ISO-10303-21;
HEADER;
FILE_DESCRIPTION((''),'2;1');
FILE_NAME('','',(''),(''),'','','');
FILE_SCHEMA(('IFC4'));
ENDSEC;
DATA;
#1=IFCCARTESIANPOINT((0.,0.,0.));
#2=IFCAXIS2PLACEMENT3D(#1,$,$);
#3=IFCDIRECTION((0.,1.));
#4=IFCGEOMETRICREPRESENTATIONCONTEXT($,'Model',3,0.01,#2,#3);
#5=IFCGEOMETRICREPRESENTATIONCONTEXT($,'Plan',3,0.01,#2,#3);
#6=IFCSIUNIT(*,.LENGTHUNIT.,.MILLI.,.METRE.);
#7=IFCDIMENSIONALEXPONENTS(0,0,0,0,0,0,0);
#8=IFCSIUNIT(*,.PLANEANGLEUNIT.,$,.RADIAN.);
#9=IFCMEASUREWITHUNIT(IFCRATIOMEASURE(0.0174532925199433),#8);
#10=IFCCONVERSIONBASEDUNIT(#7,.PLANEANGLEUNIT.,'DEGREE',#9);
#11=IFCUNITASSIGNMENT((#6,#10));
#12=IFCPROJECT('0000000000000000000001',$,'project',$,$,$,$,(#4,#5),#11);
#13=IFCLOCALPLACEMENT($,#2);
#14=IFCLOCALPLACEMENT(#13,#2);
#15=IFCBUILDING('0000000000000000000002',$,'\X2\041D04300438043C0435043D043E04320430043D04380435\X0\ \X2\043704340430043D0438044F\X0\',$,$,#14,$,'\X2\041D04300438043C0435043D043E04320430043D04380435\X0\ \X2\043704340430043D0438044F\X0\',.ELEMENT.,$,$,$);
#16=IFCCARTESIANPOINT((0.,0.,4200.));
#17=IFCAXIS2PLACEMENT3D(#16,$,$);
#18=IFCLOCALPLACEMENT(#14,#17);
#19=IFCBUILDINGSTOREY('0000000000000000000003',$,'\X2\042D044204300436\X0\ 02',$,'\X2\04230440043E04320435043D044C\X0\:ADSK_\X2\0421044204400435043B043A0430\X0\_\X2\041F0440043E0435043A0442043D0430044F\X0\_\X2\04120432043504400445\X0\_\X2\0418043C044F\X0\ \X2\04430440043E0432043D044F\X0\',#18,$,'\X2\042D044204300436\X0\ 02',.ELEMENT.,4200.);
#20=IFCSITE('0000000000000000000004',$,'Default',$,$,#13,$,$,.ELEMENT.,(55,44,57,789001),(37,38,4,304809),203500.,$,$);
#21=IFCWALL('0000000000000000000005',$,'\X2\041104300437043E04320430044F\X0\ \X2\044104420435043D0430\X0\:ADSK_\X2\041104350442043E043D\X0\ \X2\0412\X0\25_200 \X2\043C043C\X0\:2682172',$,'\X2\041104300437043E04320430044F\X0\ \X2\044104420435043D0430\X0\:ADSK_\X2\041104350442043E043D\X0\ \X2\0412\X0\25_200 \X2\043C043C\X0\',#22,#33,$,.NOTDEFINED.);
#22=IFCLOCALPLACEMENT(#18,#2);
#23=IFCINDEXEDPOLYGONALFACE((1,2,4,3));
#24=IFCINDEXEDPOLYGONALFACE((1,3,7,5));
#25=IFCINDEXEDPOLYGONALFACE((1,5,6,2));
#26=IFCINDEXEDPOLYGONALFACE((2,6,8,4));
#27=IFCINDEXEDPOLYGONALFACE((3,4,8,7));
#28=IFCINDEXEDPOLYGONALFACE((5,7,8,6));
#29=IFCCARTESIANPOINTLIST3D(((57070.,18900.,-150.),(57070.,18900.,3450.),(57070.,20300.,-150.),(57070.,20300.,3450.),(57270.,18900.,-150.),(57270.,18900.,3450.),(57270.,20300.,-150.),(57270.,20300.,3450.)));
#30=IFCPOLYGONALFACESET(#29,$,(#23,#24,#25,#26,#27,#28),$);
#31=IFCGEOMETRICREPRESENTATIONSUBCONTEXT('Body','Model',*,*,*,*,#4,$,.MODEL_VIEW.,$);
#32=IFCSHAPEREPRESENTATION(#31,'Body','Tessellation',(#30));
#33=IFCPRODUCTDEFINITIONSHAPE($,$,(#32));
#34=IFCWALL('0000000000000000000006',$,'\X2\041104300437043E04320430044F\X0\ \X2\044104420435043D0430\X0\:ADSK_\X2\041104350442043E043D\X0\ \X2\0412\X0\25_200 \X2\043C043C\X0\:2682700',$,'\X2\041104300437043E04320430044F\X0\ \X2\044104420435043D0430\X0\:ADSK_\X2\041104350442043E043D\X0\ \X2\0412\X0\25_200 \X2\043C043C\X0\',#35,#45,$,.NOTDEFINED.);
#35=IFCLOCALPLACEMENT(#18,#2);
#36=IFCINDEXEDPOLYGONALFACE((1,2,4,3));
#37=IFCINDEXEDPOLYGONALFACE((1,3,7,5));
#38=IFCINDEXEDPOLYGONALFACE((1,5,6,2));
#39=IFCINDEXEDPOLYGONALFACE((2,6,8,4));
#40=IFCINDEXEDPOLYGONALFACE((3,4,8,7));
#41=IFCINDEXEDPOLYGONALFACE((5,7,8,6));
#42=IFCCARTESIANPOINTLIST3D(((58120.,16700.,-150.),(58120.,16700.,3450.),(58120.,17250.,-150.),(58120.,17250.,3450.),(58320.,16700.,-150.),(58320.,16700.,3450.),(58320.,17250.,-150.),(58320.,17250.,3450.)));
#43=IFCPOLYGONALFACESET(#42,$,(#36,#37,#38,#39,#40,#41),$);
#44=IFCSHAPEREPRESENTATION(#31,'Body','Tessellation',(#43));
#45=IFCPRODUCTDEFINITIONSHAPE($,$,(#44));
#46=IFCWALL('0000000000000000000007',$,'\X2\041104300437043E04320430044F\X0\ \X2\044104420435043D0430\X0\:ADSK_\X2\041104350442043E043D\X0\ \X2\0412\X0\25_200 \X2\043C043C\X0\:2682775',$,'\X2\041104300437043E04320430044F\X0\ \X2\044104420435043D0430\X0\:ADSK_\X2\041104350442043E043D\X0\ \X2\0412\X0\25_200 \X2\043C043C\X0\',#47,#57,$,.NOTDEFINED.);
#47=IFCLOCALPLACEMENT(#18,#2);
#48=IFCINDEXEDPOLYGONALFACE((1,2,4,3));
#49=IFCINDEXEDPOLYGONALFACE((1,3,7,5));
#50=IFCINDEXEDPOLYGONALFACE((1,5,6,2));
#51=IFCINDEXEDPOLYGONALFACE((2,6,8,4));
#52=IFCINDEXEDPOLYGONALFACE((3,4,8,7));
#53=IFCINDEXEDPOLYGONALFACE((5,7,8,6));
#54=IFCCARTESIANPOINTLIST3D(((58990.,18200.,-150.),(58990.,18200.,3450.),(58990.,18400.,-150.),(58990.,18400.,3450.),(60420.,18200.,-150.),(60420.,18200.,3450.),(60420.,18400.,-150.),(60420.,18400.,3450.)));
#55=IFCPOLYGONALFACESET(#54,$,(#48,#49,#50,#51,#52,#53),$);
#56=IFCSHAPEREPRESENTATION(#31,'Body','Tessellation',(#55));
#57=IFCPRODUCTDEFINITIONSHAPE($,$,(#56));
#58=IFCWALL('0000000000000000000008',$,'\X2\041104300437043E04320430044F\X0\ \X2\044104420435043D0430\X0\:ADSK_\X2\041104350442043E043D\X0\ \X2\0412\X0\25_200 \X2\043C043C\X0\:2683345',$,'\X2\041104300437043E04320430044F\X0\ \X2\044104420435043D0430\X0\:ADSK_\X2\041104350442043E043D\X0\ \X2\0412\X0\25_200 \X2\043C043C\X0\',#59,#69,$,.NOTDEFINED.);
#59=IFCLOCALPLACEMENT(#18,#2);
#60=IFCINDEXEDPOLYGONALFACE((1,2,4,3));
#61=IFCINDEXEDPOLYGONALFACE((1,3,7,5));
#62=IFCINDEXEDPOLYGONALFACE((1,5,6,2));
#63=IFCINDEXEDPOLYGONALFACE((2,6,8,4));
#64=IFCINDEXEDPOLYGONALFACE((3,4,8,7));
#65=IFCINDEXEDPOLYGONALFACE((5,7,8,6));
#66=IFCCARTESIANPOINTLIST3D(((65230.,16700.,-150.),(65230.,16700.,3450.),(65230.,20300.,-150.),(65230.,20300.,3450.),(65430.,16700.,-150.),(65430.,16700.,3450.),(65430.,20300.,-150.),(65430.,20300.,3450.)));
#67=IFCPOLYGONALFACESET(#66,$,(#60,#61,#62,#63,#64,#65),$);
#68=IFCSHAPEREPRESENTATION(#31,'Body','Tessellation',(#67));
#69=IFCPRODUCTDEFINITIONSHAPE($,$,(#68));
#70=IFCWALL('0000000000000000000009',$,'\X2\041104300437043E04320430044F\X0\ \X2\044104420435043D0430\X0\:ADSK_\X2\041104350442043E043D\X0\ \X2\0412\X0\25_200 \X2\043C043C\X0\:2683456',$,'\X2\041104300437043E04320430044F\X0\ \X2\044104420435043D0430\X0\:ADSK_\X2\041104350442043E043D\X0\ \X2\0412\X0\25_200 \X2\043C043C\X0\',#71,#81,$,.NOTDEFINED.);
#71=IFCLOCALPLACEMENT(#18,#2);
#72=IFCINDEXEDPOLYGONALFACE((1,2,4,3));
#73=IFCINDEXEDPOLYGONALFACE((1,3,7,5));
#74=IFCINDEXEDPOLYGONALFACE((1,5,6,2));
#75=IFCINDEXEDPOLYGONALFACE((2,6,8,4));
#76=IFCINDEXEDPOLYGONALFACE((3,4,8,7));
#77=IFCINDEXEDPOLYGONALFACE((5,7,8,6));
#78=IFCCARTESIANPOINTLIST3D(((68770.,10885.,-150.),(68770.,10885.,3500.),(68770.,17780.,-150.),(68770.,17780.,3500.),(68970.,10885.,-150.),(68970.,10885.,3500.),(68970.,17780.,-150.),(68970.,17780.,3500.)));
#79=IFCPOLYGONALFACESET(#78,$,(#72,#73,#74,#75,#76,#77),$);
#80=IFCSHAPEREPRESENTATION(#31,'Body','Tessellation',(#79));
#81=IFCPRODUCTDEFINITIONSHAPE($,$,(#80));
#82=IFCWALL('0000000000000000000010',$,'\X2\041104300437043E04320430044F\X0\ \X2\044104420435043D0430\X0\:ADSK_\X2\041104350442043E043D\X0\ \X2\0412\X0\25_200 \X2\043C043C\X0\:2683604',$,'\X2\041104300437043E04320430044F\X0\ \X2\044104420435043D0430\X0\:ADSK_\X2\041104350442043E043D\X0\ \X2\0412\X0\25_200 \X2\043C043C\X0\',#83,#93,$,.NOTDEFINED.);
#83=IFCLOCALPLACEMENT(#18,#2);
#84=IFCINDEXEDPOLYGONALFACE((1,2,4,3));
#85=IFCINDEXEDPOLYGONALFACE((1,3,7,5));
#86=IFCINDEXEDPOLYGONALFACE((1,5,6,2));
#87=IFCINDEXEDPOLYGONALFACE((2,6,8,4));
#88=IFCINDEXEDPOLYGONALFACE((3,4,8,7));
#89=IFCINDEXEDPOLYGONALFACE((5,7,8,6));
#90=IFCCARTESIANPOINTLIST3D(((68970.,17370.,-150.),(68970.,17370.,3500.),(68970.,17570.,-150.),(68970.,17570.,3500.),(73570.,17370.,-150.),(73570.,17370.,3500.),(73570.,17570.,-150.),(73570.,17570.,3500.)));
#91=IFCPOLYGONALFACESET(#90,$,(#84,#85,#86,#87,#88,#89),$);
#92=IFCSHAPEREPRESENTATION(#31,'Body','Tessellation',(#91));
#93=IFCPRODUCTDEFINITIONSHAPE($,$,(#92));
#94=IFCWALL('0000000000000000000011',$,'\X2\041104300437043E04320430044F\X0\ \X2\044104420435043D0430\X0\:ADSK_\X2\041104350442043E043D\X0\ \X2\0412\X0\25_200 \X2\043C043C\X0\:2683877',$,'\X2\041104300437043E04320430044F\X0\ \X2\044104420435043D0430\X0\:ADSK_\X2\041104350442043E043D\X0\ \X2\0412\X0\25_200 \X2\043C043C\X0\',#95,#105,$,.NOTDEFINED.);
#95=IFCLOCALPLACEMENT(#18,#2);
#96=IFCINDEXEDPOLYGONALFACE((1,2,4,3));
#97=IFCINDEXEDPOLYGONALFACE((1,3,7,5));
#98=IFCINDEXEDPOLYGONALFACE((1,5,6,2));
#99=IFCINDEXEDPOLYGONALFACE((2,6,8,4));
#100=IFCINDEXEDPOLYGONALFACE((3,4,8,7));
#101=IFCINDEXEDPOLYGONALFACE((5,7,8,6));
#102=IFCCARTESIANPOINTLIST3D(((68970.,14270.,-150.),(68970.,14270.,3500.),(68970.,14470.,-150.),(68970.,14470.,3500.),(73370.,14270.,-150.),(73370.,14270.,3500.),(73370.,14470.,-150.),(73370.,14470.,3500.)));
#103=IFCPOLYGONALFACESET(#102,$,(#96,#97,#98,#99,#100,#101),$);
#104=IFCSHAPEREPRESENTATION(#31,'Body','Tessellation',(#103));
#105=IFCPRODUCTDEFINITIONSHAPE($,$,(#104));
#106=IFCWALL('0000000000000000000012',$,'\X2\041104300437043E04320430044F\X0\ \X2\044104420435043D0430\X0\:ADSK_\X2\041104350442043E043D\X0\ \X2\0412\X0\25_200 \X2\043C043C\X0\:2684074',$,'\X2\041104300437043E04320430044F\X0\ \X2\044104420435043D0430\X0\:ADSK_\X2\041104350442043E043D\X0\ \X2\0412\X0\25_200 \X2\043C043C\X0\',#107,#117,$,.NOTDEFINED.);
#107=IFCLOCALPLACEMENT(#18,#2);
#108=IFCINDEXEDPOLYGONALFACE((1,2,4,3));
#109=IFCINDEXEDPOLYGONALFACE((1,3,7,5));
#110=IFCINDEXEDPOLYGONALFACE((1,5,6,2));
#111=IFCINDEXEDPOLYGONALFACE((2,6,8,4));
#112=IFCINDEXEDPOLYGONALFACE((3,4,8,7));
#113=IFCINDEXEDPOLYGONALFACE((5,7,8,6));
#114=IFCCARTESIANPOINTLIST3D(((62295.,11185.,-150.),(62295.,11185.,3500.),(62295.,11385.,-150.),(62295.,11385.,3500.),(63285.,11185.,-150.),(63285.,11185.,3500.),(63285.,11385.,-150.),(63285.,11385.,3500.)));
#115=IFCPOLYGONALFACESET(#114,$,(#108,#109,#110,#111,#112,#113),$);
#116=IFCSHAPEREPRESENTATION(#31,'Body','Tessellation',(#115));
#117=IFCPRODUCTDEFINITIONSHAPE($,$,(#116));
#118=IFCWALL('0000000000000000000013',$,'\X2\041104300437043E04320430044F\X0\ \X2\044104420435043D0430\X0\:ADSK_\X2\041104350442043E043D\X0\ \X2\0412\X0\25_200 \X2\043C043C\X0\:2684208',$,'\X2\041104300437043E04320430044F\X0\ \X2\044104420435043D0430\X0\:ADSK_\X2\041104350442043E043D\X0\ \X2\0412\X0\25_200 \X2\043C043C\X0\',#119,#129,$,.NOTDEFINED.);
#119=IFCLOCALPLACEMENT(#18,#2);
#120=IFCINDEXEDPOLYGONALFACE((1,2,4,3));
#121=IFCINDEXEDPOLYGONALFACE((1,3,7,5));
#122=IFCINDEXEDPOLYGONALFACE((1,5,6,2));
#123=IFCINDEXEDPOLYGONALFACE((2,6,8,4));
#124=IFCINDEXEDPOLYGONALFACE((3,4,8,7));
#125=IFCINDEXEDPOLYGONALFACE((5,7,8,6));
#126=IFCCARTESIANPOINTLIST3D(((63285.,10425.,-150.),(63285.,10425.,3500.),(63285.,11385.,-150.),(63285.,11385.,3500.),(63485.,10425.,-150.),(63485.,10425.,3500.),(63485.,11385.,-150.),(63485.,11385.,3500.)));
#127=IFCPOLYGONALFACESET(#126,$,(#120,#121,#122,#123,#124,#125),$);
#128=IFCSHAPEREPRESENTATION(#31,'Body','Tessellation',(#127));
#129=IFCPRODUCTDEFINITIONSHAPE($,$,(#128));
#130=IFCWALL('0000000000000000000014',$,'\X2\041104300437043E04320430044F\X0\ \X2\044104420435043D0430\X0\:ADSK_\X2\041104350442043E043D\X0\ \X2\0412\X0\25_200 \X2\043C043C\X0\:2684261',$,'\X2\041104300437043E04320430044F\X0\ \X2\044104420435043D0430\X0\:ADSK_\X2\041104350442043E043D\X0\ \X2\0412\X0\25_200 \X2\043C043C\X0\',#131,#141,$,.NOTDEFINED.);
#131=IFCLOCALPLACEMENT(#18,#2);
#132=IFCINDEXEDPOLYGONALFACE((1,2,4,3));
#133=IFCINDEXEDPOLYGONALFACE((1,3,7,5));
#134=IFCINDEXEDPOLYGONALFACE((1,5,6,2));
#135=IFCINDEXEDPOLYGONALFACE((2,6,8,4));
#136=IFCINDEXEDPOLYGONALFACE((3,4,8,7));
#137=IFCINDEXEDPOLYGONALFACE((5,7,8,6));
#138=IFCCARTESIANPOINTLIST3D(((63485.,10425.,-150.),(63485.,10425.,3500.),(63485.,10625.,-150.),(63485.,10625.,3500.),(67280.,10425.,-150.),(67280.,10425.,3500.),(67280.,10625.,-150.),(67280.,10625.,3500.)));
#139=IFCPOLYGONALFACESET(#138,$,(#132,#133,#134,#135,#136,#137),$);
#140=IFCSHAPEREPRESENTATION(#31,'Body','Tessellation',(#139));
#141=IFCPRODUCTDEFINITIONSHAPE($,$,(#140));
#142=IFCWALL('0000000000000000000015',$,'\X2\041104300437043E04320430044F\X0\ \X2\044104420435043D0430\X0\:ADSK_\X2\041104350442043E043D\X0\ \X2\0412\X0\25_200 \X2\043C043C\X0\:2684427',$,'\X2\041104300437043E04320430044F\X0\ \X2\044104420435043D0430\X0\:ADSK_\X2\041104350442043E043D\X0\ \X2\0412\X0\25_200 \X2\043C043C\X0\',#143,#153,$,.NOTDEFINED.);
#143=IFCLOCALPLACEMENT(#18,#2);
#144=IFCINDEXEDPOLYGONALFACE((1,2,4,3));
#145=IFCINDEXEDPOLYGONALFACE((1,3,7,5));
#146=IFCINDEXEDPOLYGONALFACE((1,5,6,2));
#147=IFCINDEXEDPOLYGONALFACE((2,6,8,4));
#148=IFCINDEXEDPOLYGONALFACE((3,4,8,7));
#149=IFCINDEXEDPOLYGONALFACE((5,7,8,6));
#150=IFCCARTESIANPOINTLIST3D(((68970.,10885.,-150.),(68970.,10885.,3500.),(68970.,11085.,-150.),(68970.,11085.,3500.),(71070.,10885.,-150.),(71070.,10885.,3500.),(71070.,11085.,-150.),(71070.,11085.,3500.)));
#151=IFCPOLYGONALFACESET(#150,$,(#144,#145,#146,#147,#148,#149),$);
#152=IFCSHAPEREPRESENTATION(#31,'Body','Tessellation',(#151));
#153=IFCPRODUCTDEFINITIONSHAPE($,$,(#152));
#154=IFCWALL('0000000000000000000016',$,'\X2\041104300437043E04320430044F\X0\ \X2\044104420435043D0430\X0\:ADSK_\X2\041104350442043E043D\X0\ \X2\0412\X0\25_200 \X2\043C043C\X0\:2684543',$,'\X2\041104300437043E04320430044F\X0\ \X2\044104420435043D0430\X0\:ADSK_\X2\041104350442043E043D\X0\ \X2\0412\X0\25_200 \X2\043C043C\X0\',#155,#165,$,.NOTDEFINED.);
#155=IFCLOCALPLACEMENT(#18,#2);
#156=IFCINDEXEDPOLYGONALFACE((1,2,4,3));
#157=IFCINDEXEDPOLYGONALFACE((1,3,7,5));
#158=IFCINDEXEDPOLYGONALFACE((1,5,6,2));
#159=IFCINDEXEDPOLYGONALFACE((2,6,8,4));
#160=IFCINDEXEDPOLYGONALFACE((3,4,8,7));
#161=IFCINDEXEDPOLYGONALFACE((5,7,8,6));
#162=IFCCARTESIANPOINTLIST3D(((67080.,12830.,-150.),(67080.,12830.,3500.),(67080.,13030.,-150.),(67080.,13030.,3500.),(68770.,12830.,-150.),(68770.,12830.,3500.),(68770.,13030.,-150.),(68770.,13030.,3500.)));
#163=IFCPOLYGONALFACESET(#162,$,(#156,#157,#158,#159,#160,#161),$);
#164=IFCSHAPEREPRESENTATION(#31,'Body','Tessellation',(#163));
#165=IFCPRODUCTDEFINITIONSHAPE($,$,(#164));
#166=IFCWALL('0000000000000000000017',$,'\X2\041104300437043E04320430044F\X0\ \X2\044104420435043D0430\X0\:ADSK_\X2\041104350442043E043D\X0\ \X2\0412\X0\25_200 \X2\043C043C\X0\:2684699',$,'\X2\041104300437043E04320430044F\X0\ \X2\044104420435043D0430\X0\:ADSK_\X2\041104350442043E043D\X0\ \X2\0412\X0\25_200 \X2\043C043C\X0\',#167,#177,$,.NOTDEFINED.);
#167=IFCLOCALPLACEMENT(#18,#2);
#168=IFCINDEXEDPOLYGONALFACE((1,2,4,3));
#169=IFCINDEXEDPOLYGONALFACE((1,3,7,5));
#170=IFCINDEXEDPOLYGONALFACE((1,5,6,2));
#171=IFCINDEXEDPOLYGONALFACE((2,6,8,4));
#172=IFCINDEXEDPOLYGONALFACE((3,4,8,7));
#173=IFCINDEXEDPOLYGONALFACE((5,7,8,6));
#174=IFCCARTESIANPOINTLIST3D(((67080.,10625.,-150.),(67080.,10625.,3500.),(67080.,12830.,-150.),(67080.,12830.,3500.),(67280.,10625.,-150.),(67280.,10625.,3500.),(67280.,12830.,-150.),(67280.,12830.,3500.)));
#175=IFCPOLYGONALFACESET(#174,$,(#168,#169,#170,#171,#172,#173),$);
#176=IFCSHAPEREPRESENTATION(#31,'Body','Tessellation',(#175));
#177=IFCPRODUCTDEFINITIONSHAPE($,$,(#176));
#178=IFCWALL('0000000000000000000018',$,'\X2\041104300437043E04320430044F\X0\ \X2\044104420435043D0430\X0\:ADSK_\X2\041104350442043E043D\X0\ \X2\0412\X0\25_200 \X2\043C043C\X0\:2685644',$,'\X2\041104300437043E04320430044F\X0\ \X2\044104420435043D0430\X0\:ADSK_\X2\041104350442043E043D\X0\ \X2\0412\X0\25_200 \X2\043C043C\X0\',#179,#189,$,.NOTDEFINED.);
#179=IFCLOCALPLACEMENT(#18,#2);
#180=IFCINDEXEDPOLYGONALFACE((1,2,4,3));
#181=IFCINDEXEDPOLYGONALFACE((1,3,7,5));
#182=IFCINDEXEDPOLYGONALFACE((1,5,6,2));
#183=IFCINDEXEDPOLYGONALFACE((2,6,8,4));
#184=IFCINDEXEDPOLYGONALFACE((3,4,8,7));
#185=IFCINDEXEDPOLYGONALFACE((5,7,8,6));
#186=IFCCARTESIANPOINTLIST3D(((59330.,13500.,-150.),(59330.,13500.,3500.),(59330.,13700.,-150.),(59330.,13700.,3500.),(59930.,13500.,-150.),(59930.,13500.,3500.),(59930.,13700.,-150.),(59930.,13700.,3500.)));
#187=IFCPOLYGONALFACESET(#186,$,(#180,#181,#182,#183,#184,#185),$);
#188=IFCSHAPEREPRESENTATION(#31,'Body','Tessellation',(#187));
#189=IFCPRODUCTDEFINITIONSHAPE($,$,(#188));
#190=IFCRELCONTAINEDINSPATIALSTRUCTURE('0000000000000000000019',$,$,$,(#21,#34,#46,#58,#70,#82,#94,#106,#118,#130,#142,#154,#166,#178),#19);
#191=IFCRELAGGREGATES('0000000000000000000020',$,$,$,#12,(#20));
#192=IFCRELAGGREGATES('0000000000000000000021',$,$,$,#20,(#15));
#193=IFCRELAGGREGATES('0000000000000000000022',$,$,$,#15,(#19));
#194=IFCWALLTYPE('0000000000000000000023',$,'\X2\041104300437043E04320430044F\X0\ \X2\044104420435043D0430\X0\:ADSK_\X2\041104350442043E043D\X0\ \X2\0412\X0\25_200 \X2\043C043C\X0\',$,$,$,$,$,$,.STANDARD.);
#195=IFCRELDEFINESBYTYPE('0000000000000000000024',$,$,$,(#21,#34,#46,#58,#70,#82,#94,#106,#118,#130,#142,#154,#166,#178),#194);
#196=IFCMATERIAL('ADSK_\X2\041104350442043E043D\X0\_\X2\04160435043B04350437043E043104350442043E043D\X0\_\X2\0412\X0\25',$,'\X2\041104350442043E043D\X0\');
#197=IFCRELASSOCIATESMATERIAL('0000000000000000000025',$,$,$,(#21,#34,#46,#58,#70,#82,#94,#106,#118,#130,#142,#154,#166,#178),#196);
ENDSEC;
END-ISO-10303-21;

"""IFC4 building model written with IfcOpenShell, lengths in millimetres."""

from ifc_helpers import new_model, entity, si_unit, converted_unit, direction, frame, origin, place, context, subcontext, project, spatial, indexed_curve, outline, extrude, material, type_object, element, save


model = new_model("IFC4")

# Units and contexts
model_context = context("Model", 3, precision=0.01, world=origin(), true_north=direction((0.0, 1.0)))
plan_context = context("Plan", 3, precision=0.01, world=origin(), true_north=direction((0.0, 1.0)))
body_context = subcontext(model_context, "Body", "Model", "MODEL_VIEW")
ifc_project = project(units=[si_unit("LENGTHUNIT", "METRE", prefix="MILLI"), converted_unit("PLANEANGLEUNIT", "DEGREE", entity("IfcRatioMeasure", 0.0174532925199433), si_unit("PLANEANGLEUNIT", "RADIAN"), dimensions=[0, 0, 0, 0, 0, 0, 0])], contexts=[model_context, plan_context])

# Site, building, storey
site_placement = place(None, origin())
site = spatial("IfcSite", under=ifc_project, at=site_placement, Name="Default", CompositionType="ELEMENT", RefLatitude=(55, 44, 57, 789001), RefLongitude=(37, 38, 4, 304809), RefElevation=203500.0)
building_placement = place(site_placement, origin())
building = spatial("IfcBuilding", under=site, at=building_placement, Name="Наименование здания", LongName="Наименование здания", CompositionType="ELEMENT")
storey_placement = place(building_placement, frame((0.0, 0.0, 4200.0)))
storey = spatial("IfcBuildingStorey", under=building, at=storey_placement, Name="Этаж 02", ObjectType="Уровень:ADSK_Стрелка_Проектная_Вверх_Имя уровня", LongName="Этаж 02", CompositionType="ELEMENT", Elevation=4200.0)

# Walls
ifc_material = material(Name="ADSK_Бетон_Железобетон_В25", Category="Бетон")
wall_type_1 = type_object("IfcWallType", Name="Базовая стена:ADSK_Бетон В25_200 мм", PredefinedType="STANDARD")
wall_1_placement = place(storey_placement, frame((57170.0, 20300.0, -150.0), z_axis=(0.0, 0.0, 1.0), x_axis=(0.0, -1.0, 0.0)))
element("IfcWall", 1, at=wall_1_placement, inside=storey, type_object=wall_type_1, material=ifc_material, Name="Базовая стена:ADSK_Бетон В25_200 мм:2682172", ObjectType="Базовая стена:ADSK_Бетон В25_200 мм", PredefinedType="NOTDEFINED", context=body_context, shape_type="SweptSolid", body=[
    extrude(outline(indexed_curve([(1400.0, 100.0), (0.0, 100.0), (0.0, -100.0), (1400.0, -100.0), (1400.0, 100.0)], self_intersect=False)), origin(), (0.0, 0.0, 1.0), 3600.0),
])
wall_2_placement = place(storey_placement, frame((58220.0, 16700.0, -150.0), z_axis=(0.0, 0.0, 1.0), x_axis=(0.0, 1.0, 0.0)))
element("IfcWall", 2, at=wall_2_placement, inside=storey, type_object=wall_type_1, material=ifc_material, Name="Базовая стена:ADSK_Бетон В25_200 мм:2682700", ObjectType="Базовая стена:ADSK_Бетон В25_200 мм", PredefinedType="NOTDEFINED", context=body_context, shape_type="SweptSolid", body=[
    extrude(outline(indexed_curve([(550.0, 100.0), (0.0, 100.0), (0.0, -100.0), (550.0, -100.0), (550.0, 100.0)], self_intersect=False)), origin(), (0.0, 0.0, 1.0), 3600.0),
])
wall_3_placement = place(storey_placement, frame((60420.0, 18300.0, -150.0), z_axis=(0.0, 0.0, 1.0), x_axis=(-1.0, 0.0, 0.0)))
element("IfcWall", 3, at=wall_3_placement, inside=storey, type_object=wall_type_1, material=ifc_material, Name="Базовая стена:ADSK_Бетон В25_200 мм:2682775", ObjectType="Базовая стена:ADSK_Бетон В25_200 мм", PredefinedType="NOTDEFINED", context=body_context, shape_type="SweptSolid", body=[
    extrude(outline(indexed_curve([(1430.0, 100.0), (0.0, 100.0), (0.0, -100.0), (1430.0, -100.0), (1430.0, 100.0)], self_intersect=False)), origin(), (0.0, 0.0, 1.0), 3600.0),
])
wall_4_placement = place(storey_placement, frame((65330.0, 16700.0, -150.0), z_axis=(0.0, 0.0, 1.0), x_axis=(0.0, 1.0, 0.0)))
element("IfcWall", 4, at=wall_4_placement, inside=storey, type_object=wall_type_1, material=ifc_material, Name="Базовая стена:ADSK_Бетон В25_200 мм:2683345", ObjectType="Базовая стена:ADSK_Бетон В25_200 мм", PredefinedType="NOTDEFINED", context=body_context, shape_type="SweptSolid", body=[
    extrude(outline(indexed_curve([(3600.0, 100.0), (0.0, 100.0), (0.0, -100.0), (3600.0, -100.0), (3600.0, 100.0)], self_intersect=False)), origin(), (0.0, 0.0, 1.0), 3600.0),
])
wall_5_placement = place(storey_placement, frame((68870.0, 17780.0, -150.0), z_axis=(0.0, 0.0, 1.0), x_axis=(0.0, -1.0, 0.0)))
element("IfcWall", 5, at=wall_5_placement, inside=storey, type_object=wall_type_1, material=ifc_material, Name="Базовая стена:ADSK_Бетон В25_200 мм:2683456", ObjectType="Базовая стена:ADSK_Бетон В25_200 мм", PredefinedType="NOTDEFINED", context=body_context, shape_type="SweptSolid", body=[
    extrude(outline(indexed_curve([(6895.0, 100.0), (0.0, 100.0), (0.0, -100.0), (6895.0, -100.0), (6895.0, 100.0)], self_intersect=False)), origin(), (0.0, 0.0, 1.0), 3650.0),
])
wall_6_placement = place(storey_placement, frame((68970.0, 17470.0, -150.0)))
element("IfcWall", 6, at=wall_6_placement, inside=storey, type_object=wall_type_1, material=ifc_material, Name="Базовая стена:ADSK_Бетон В25_200 мм:2683604", ObjectType="Базовая стена:ADSK_Бетон В25_200 мм", PredefinedType="NOTDEFINED", context=body_context, shape_type="SweptSolid", body=[
    extrude(outline(indexed_curve([(4600.0, 100.0), (0.0, 100.0), (0.0, -100.0), (4600.0, -100.0), (4600.0, 100.0)], self_intersect=False)), origin(), (0.0, 0.0, 1.0), 3650.0),
])
wall_7_placement = place(storey_placement, frame((73370.0, 14370.0, -150.0), z_axis=(0.0, 0.0, 1.0), x_axis=(-1.0, 0.0, 0.0)))
element("IfcWall", 7, at=wall_7_placement, inside=storey, type_object=wall_type_1, material=ifc_material, Name="Базовая стена:ADSK_Бетон В25_200 мм:2683877", ObjectType="Базовая стена:ADSK_Бетон В25_200 мм", PredefinedType="NOTDEFINED", context=body_context, shape_type="SweptSolid", body=[
    extrude(outline(indexed_curve([(4400.0, 100.0), (0.0, 100.0), (0.0, -100.0), (4400.0, -100.0), (4400.0, 100.0)], self_intersect=False)), origin(), (0.0, 0.0, 1.0), 3650.0),
])
wall_8_placement = place(storey_placement, frame((62295.0, 11285.0, -150.0)))
element("IfcWall", 8, at=wall_8_placement, inside=storey, type_object=wall_type_1, material=ifc_material, Name="Базовая стена:ADSK_Бетон В25_200 мм:2684074", ObjectType="Базовая стена:ADSK_Бетон В25_200 мм", PredefinedType="NOTDEFINED", context=body_context, shape_type="SweptSolid", body=[
    extrude(outline(indexed_curve([(990.0, 100.0), (0.0, 100.0), (0.0, -100.0), (990.0, -100.0), (990.0, 100.0)], self_intersect=False)), origin(), (0.0, 0.0, 1.0), 3650.0),
])
wall_9_placement = place(storey_placement, frame((63385.0, 11385.0, -150.0), z_axis=(0.0, 0.0, 1.0), x_axis=(0.0, -1.0, 0.0)))
element("IfcWall", 9, at=wall_9_placement, inside=storey, type_object=wall_type_1, material=ifc_material, Name="Базовая стена:ADSK_Бетон В25_200 мм:2684208", ObjectType="Базовая стена:ADSK_Бетон В25_200 мм", PredefinedType="NOTDEFINED", context=body_context, shape_type="SweptSolid", body=[
    extrude(outline(indexed_curve([(960.0, 100.0), (0.0, 100.0), (0.0, -100.0), (960.0, -100.0), (960.0, 100.0)], self_intersect=False)), origin(), (0.0, 0.0, 1.0), 3650.0),
])
wall_10_placement = place(storey_placement, frame((63485.0, 10525.0, -150.0)))
element("IfcWall", 10, at=wall_10_placement, inside=storey, type_object=wall_type_1, material=ifc_material, Name="Базовая стена:ADSK_Бетон В25_200 мм:2684261", ObjectType="Базовая стена:ADSK_Бетон В25_200 мм", PredefinedType="NOTDEFINED", context=body_context, shape_type="SweptSolid", body=[
    extrude(outline(indexed_curve([(3795.0, 100.0), (0.0, 100.0), (0.0, -100.0), (3795.0, -100.0), (3795.0, 100.0)], self_intersect=False)), origin(), (0.0, 0.0, 1.0), 3650.0),
])
wall_11_placement = place(storey_placement, frame((71070.0, 10985.0, -150.0), z_axis=(0.0, 0.0, 1.0), x_axis=(-1.0, 0.0, 0.0)))
element("IfcWall", 11, at=wall_11_placement, inside=storey, type_object=wall_type_1, material=ifc_material, Name="Базовая стена:ADSK_Бетон В25_200 мм:2684427", ObjectType="Базовая стена:ADSK_Бетон В25_200 мм", PredefinedType="NOTDEFINED", context=body_context, shape_type="SweptSolid", body=[
    extrude(outline(indexed_curve([(2100.0, 100.0), (0.0, 100.0), (0.0, -100.0), (2100.0, -100.0), (2100.0, 100.0)], self_intersect=False)), origin(), (0.0, 0.0, 1.0), 3650.0),
])
wall_12_placement = place(storey_placement, frame((68770.0, 12930.0, -150.0), z_axis=(0.0, 0.0, 1.0), x_axis=(-1.0, 0.0, 0.0)))
element("IfcWall", 12, at=wall_12_placement, inside=storey, type_object=wall_type_1, material=ifc_material, Name="Базовая стена:ADSK_Бетон В25_200 мм:2684543", ObjectType="Базовая стена:ADSK_Бетон В25_200 мм", PredefinedType="NOTDEFINED", context=body_context, shape_type="SweptSolid", body=[
    extrude(outline(indexed_curve([(1690.0, 100.0), (0.0, 100.0), (0.0, -100.0), (1690.0, -100.0), (1690.0, 100.0)], self_intersect=False)), origin(), (0.0, 0.0, 1.0), 3650.0),
])
wall_13_placement = place(storey_placement, frame((67180.0, 12830.0, -150.0), z_axis=(0.0, 0.0, 1.0), x_axis=(0.0, -1.0, 0.0)))
element("IfcWall", 13, at=wall_13_placement, inside=storey, type_object=wall_type_1, material=ifc_material, Name="Базовая стена:ADSK_Бетон В25_200 мм:2684699", ObjectType="Базовая стена:ADSK_Бетон В25_200 мм", PredefinedType="NOTDEFINED", context=body_context, shape_type="SweptSolid", body=[
    extrude(outline(indexed_curve([(2205.0, 100.0), (0.0, 100.0), (0.0, -100.0), (2205.0, -100.0), (2205.0, 100.0)], self_intersect=False)), origin(), (0.0, 0.0, 1.0), 3650.0),
])
wall_14_placement = place(storey_placement, frame((59330.0, 13600.0, -150.0)))
element("IfcWall", 14, at=wall_14_placement, inside=storey, type_object=wall_type_1, material=ifc_material, Name="Базовая стена:ADSK_Бетон В25_200 мм:2685644", ObjectType="Базовая стена:ADSK_Бетон В25_200 мм", PredefinedType="NOTDEFINED", context=body_context, shape_type="SweptSolid", body=[
    extrude(outline(indexed_curve([(600.0, 100.0), (0.0, 100.0), (0.0, -100.0), (600.0, -100.0), (600.0, 100.0)], self_intersect=False)), origin(), (0.0, 0.0, 1.0), 3650.0),
])

save(model, "model.ifc")
